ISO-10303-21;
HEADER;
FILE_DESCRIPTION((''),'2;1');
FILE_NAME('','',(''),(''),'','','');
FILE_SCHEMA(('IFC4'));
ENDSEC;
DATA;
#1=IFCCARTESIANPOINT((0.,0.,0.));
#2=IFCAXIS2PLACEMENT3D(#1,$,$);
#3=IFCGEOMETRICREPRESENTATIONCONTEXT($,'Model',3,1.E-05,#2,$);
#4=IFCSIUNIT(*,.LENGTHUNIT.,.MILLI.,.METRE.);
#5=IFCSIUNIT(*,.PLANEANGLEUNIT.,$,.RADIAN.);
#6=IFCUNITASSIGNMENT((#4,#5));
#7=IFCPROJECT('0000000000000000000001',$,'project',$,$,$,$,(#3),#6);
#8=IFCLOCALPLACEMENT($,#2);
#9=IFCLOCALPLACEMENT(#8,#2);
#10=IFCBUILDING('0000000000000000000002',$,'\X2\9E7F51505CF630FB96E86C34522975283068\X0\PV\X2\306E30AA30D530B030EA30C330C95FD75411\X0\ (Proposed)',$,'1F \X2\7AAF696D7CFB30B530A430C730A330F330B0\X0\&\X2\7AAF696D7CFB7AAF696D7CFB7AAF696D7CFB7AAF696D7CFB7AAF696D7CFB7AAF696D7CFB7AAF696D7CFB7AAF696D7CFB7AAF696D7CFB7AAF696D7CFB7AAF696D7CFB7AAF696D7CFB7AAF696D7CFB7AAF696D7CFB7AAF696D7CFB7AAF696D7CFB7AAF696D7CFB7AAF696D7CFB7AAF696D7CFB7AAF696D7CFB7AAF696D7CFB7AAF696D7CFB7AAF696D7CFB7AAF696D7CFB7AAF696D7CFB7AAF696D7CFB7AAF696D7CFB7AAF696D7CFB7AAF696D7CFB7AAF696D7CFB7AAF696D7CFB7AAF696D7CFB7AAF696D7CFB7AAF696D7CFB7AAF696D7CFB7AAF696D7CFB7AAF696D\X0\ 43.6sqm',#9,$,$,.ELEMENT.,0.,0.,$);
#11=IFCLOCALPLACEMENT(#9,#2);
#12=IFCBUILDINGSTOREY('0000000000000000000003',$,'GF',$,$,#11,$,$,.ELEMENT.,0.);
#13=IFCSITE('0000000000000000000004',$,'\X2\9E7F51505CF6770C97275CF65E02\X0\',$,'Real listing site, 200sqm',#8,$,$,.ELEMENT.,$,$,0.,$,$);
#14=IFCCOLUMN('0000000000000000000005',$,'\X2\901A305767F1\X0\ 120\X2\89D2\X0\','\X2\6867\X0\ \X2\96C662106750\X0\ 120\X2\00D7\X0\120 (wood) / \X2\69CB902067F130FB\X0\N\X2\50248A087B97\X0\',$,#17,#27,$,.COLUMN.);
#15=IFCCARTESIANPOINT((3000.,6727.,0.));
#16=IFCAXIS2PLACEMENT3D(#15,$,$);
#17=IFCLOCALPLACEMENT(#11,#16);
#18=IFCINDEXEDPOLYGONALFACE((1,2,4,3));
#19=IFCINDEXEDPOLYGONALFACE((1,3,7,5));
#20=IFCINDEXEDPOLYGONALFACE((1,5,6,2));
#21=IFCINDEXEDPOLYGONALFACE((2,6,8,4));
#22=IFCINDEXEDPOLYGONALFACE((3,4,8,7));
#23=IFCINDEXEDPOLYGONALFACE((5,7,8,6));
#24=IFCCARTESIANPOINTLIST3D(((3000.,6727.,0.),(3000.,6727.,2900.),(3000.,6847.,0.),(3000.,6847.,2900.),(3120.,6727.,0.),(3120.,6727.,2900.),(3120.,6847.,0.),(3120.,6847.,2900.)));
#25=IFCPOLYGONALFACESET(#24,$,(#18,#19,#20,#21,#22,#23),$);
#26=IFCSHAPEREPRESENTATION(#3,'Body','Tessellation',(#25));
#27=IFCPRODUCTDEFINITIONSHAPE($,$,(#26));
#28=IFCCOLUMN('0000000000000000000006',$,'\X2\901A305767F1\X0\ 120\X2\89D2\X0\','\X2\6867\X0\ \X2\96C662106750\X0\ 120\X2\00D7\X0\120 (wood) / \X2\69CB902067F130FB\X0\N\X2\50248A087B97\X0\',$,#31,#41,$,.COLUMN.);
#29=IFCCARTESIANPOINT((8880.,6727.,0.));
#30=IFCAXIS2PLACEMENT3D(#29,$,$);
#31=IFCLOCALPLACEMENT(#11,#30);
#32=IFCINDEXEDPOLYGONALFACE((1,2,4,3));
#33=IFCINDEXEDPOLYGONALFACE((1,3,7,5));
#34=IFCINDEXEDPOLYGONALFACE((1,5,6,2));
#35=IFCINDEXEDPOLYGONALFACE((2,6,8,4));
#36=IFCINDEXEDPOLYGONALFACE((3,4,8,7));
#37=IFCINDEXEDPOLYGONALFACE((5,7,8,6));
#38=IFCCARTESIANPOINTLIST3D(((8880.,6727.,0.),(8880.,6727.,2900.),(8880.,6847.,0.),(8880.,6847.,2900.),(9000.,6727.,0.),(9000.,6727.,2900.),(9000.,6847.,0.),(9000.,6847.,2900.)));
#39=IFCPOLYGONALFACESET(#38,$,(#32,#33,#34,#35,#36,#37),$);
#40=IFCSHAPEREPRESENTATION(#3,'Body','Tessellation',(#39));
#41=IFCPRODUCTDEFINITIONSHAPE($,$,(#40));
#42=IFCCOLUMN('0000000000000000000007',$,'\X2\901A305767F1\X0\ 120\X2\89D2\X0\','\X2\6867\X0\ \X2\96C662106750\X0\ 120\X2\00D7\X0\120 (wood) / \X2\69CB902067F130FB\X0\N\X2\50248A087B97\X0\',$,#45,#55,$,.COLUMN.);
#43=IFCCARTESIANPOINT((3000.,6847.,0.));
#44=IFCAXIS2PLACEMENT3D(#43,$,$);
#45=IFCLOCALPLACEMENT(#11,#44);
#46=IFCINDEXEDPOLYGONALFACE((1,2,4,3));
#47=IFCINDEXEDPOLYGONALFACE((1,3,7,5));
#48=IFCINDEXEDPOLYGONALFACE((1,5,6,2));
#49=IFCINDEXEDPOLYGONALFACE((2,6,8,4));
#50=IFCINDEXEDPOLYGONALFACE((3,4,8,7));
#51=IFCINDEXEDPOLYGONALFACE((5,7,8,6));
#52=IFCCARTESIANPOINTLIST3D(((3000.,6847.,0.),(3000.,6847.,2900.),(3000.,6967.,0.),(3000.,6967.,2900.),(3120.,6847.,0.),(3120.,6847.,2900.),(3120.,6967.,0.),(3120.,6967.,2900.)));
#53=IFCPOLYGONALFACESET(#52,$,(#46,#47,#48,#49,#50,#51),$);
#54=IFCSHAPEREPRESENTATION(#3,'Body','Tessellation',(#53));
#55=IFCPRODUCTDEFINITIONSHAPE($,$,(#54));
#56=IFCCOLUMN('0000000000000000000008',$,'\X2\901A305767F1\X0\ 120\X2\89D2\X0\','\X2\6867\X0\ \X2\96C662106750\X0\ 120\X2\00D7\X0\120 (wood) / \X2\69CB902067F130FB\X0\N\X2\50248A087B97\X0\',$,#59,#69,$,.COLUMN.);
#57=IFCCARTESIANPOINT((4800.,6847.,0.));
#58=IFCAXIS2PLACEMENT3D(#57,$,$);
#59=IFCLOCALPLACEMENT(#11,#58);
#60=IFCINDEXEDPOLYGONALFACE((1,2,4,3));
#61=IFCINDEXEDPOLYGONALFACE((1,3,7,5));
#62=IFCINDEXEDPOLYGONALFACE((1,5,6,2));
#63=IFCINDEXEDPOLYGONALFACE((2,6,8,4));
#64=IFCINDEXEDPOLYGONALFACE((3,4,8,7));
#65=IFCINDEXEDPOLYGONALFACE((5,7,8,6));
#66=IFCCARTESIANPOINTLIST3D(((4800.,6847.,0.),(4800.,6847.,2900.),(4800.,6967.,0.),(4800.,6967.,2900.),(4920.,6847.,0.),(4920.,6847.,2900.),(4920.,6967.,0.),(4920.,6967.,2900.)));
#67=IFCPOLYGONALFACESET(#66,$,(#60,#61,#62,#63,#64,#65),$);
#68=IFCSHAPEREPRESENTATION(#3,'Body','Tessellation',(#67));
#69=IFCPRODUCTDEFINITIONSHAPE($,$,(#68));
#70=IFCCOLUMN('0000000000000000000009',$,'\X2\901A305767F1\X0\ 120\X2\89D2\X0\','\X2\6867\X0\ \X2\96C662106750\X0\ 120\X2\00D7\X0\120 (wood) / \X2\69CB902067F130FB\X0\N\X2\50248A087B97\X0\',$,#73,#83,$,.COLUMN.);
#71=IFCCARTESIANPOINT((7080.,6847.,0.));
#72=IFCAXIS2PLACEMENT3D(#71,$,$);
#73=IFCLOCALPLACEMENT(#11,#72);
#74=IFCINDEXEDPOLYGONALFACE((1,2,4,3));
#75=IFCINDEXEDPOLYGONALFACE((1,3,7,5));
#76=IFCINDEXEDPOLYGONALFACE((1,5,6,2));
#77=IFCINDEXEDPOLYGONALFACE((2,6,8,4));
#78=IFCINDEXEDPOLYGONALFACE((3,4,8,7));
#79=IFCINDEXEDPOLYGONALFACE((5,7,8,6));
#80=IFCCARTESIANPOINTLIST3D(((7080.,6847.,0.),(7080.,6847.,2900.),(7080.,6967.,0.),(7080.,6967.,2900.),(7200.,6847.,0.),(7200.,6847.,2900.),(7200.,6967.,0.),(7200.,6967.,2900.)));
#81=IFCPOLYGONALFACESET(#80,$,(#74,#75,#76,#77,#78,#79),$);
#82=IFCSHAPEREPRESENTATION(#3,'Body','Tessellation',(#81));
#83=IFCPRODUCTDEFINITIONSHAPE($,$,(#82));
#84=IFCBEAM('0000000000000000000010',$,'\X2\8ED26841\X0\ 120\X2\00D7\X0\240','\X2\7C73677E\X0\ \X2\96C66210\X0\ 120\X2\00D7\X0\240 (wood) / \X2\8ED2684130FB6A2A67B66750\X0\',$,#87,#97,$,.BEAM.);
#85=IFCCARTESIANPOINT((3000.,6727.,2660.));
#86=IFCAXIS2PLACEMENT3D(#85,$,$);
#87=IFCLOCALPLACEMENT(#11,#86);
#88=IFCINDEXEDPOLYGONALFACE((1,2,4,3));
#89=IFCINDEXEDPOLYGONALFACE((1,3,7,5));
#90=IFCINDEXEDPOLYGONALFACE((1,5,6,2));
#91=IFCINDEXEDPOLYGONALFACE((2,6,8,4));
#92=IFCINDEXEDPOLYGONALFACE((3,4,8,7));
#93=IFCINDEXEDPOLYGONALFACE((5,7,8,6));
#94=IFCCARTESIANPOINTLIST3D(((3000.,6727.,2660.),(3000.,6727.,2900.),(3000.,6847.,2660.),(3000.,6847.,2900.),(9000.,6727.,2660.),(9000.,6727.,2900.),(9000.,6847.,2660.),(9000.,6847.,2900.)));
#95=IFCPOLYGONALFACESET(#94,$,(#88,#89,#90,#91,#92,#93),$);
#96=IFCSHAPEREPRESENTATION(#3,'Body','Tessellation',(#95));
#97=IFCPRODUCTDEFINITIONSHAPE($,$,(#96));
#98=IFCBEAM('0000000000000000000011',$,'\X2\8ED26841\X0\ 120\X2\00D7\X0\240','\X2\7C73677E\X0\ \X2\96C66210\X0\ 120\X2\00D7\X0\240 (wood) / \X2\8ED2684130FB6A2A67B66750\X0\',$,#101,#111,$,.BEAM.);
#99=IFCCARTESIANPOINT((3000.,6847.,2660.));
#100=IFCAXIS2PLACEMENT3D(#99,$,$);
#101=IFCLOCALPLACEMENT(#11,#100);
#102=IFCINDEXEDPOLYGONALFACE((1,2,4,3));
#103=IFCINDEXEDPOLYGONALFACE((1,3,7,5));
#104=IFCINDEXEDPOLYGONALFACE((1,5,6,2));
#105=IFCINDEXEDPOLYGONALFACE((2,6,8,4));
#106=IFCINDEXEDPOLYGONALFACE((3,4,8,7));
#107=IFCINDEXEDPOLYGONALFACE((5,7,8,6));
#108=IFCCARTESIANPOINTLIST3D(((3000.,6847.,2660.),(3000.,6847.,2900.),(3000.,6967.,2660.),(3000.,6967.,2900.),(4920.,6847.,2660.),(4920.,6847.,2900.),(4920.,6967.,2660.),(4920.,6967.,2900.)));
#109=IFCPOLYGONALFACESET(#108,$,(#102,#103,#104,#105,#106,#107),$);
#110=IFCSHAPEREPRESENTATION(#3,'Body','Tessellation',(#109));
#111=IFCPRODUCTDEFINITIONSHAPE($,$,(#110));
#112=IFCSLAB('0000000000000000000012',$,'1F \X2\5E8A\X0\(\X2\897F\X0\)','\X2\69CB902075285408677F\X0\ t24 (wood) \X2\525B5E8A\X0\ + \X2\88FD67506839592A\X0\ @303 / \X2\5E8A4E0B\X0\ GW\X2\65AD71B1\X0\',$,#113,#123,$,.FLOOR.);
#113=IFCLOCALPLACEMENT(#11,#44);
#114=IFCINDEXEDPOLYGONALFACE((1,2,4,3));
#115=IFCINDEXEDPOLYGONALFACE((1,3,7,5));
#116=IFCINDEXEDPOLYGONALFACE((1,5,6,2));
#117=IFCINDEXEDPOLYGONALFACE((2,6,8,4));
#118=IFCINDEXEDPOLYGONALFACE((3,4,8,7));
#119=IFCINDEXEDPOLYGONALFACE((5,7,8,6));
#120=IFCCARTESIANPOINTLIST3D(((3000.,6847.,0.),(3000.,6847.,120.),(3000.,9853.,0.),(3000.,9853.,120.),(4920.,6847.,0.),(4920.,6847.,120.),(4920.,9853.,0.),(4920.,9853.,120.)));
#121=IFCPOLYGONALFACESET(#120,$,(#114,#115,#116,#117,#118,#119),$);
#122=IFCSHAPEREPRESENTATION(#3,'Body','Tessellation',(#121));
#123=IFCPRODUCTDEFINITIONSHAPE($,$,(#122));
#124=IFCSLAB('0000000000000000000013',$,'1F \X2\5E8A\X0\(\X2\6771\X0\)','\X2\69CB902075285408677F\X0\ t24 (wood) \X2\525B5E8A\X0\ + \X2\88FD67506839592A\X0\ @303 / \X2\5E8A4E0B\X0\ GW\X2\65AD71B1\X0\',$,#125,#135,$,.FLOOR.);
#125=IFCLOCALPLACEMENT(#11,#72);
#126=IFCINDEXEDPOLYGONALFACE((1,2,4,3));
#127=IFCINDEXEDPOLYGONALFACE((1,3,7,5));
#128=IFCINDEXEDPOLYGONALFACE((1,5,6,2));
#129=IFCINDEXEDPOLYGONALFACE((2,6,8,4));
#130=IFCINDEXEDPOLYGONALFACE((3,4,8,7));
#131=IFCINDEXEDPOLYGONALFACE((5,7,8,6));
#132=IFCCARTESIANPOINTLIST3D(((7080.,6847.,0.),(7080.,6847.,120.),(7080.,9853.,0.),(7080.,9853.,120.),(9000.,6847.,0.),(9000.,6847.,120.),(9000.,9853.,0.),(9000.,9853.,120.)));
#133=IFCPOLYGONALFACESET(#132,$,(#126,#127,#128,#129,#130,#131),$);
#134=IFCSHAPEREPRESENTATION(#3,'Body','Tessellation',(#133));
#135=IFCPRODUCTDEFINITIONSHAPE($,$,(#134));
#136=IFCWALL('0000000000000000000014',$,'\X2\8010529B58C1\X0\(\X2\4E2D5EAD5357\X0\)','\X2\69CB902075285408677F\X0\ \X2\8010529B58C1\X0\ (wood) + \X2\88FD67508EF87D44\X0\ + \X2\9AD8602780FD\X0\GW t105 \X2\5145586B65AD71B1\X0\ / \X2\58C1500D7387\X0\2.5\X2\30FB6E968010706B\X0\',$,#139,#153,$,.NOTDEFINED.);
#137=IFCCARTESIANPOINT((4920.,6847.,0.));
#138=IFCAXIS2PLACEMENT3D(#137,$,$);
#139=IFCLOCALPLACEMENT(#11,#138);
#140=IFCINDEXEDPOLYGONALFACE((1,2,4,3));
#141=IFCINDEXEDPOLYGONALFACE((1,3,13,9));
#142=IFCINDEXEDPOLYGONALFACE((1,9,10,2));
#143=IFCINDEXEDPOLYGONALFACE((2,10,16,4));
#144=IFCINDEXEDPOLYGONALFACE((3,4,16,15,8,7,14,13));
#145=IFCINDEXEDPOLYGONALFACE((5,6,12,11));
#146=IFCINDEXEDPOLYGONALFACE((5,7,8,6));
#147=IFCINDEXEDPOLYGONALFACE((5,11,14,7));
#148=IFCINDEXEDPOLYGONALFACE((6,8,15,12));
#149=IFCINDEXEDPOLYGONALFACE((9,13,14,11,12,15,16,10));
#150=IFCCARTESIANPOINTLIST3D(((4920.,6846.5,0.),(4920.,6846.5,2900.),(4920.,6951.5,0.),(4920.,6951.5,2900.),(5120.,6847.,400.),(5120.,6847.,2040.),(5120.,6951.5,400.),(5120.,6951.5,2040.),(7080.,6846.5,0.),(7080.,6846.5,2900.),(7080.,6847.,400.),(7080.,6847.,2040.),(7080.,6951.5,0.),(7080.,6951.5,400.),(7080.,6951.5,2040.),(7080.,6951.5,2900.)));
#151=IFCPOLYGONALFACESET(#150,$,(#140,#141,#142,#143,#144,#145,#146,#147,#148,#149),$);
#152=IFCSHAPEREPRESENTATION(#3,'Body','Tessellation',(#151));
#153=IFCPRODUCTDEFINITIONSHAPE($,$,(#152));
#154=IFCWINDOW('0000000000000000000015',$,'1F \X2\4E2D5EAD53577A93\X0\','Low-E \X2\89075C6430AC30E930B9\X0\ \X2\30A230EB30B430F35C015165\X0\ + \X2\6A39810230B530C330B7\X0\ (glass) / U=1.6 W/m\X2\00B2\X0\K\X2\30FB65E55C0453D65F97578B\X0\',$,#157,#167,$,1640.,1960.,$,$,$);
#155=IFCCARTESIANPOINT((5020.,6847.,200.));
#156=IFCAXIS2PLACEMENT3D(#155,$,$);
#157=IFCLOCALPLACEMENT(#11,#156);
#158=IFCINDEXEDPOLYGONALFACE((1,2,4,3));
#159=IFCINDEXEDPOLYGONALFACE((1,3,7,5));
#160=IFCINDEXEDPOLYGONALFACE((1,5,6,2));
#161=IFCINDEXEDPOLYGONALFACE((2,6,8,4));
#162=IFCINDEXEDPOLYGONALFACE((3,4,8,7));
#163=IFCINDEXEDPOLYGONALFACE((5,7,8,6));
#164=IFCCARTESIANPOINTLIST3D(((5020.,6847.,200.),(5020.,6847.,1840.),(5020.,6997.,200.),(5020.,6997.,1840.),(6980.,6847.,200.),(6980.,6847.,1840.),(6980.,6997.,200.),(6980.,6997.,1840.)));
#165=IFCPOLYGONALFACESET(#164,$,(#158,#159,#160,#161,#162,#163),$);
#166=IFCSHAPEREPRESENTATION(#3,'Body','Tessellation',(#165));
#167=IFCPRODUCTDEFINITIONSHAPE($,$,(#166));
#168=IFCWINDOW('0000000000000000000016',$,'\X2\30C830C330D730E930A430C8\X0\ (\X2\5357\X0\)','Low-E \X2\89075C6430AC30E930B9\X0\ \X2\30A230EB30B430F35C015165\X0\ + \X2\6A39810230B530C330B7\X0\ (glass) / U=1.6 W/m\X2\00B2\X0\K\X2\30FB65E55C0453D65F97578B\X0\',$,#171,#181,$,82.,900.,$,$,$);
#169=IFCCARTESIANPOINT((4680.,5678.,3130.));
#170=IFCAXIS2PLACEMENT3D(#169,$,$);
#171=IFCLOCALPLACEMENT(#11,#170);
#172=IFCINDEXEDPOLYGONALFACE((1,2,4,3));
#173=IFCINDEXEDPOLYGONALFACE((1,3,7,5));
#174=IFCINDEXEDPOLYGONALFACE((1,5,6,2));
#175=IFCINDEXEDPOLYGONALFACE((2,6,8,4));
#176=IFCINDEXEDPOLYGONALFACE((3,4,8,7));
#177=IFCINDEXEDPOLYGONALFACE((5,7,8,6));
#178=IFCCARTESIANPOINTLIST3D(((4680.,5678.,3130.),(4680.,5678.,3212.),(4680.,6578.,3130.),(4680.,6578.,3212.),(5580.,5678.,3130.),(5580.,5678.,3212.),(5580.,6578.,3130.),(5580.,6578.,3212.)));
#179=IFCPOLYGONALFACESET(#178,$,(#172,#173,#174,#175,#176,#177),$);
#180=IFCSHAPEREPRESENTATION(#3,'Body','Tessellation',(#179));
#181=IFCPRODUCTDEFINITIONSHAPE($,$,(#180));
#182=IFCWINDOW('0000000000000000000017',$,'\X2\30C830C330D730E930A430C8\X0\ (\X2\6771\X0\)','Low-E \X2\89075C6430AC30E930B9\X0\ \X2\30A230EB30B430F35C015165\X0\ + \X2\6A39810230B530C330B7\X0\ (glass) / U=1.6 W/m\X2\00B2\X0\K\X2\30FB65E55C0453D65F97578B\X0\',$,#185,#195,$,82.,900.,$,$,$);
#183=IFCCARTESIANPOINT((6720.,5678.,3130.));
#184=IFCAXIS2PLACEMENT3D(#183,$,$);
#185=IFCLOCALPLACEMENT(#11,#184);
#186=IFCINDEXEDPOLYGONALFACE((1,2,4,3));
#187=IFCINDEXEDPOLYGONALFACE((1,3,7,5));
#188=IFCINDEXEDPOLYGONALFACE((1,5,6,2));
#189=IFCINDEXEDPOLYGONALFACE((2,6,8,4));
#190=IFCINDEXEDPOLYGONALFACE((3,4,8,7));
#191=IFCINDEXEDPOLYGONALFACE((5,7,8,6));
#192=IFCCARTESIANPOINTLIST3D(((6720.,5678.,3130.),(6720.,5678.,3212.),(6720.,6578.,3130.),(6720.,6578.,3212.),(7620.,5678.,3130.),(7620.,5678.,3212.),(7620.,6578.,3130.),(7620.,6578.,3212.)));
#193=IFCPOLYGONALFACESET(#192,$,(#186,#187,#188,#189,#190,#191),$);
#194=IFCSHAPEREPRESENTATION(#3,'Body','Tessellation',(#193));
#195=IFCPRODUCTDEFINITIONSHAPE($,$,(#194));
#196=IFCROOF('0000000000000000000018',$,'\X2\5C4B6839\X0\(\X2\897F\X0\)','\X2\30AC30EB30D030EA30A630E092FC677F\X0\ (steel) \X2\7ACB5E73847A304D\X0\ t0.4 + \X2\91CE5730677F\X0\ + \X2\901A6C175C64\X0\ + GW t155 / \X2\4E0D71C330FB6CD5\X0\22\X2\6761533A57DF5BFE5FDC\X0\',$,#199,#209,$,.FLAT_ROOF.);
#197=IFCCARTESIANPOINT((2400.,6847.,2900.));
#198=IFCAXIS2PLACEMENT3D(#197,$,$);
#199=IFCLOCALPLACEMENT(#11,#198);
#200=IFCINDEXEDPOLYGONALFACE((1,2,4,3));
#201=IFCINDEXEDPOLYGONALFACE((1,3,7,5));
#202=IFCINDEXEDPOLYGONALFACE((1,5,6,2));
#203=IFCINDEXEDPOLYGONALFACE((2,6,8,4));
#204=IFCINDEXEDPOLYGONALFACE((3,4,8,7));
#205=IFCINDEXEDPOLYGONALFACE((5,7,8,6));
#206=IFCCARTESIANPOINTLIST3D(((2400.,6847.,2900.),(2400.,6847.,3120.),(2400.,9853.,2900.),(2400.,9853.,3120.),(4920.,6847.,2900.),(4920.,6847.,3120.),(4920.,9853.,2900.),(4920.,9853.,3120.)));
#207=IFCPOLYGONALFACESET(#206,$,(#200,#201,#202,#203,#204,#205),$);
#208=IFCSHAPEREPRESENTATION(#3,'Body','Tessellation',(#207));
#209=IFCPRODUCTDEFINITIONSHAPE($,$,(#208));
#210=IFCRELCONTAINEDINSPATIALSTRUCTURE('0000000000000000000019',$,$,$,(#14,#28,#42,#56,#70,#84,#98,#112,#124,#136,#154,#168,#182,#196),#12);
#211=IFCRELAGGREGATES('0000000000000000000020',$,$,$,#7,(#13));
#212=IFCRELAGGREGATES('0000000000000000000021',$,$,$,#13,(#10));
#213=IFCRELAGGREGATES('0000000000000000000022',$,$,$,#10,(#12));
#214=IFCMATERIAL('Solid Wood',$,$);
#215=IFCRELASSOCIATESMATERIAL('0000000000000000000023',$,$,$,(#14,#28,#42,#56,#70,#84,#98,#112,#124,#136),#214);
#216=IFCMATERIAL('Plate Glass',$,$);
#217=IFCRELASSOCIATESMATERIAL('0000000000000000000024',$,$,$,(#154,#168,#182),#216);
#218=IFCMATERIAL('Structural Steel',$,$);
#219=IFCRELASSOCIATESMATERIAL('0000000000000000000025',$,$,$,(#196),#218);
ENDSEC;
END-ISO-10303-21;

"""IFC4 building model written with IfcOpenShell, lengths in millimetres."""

from ifc_helpers import new_model, si_unit, frame, frame_2d, origin, place, context, project, spatial, rectangle, extrude, material, element, fill, save


model = new_model("IFC4")

# Units and contexts
model_context = context("Model", 3, precision=1e-05, world=origin())
ifc_project = project(units=[si_unit("LENGTHUNIT", "METRE", prefix="MILLI"), si_unit("PLANEANGLEUNIT", "RADIAN")], contexts=[model_context])

# Site, building, storey
site_placement = place(None, origin())
site = spatial("IfcSite", under=ifc_project, at=site_placement, Name="鹿児島県霧島市", ObjectType="Real listing site, 200sqm", CompositionType="ELEMENT", RefElevation=0.0)
building_placement = place(site_placement, origin())
building = spatial("IfcBuilding", under=site, at=building_placement, Name="鹿児島・雨水利用とPVのオフグリッド志向 (Proposed)", ObjectType="1F 窯業系サイディング&窯業系窯業系窯業系窯業系窯業系窯業系窯業系窯業系窯業系窯業系窯業系窯業系窯業系窯業系窯業系窯業系窯業系窯業系窯業系窯業系窯業系窯業系窯業系窯業系窯業系窯業系窯業系窯業系窯業系窯業系窯業系窯業系窯業系窯業系窯業系窯業系窯業 43.6sqm", CompositionType="ELEMENT", ElevationOfRefHeight=0.0, ElevationOfTerrain=0.0)
storey_placement = place(building_placement, origin())
storey = spatial("IfcBuildingStorey", under=building, at=storey_placement, Name="GF", CompositionType="ELEMENT", Elevation=0.0)

# Columns
ifc_material_1 = material(Name="Solid Wood")
column_1_placement = place(storey_placement, frame((3000.0, 6727.0, 0.0)))
element("IfcColumn", 1, at=column_1_placement, inside=storey, material=ifc_material_1, Name="通し柱 120角", Description="桧 集成材 120×120 (wood) / 構造柱・N値計算", PredefinedType="COLUMN", context=model_context, shape_type="SweptSolid", body=[
    extrude(rectangle(XDim=120.0, YDim=120.0, at=frame_2d((60.0, 60.0))), frame((3000.0, 6727.0, 0.0)), (0.0, 0.0, 1.0), 2900.0),
])
column_2_placement = place(storey_placement, frame((8880.0, 6727.0, 0.0)))
element("IfcColumn", 2, at=column_2_placement, inside=storey, material=ifc_material_1, Name="通し柱 120角", Description="桧 集成材 120×120 (wood) / 構造柱・N値計算", PredefinedType="COLUMN", context=model_context, shape_type="SweptSolid", body=[
    extrude(rectangle(XDim=120.0, YDim=120.0, at=frame_2d((60.0, 60.0))), frame((8880.0, 6727.0, 0.0)), (0.0, 0.0, 1.0), 2900.0),
])
column_3_placement = place(storey_placement, frame((3000.0, 6847.0, 0.0)))
element("IfcColumn", 3, at=column_3_placement, inside=storey, material=ifc_material_1, Name="通し柱 120角", Description="桧 集成材 120×120 (wood) / 構造柱・N値計算", PredefinedType="COLUMN", context=model_context, shape_type="SweptSolid", body=[
    extrude(rectangle(XDim=120.0, YDim=120.0, at=frame_2d((60.0, 60.0))), frame((3000.0, 6847.0, 0.0)), (0.0, 0.0, 1.0), 2900.0),
])
column_4_placement = place(storey_placement, frame((4800.0, 6847.0, 0.0)))
element("IfcColumn", 4, at=column_4_placement, inside=storey, material=ifc_material_1, Name="通し柱 120角", Description="桧 集成材 120×120 (wood) / 構造柱・N値計算", PredefinedType="COLUMN", context=model_context, shape_type="SweptSolid", body=[
    extrude(rectangle(XDim=120.0, YDim=120.0, at=frame_2d((60.0, 60.0))), frame((4800.0, 6847.0, 0.0)), (0.0, 0.0, 1.0), 2900.0),
])
column_5_placement = place(storey_placement, frame((7080.0, 6847.0, 0.0)))
element("IfcColumn", 5, at=column_5_placement, inside=storey, material=ifc_material_1, Name="通し柱 120角", Description="桧 集成材 120×120 (wood) / 構造柱・N値計算", PredefinedType="COLUMN", context=model_context, shape_type="SweptSolid", body=[
    extrude(rectangle(XDim=120.0, YDim=120.0, at=frame_2d((60.0, 60.0))), frame((7080.0, 6847.0, 0.0)), (0.0, 0.0, 1.0), 2900.0),
])

# Beams
beam_1_placement = place(storey_placement, frame((3000.0, 6727.0, 2660.0)))
element("IfcBeam", 6, at=beam_1_placement, inside=storey, material=ifc_material_1, Name="軒桁 120×240", Description="米松 集成 120×240 (wood) / 軒桁・横架材", PredefinedType="BEAM", context=model_context, shape_type="SweptSolid", body=[
    extrude(rectangle(XDim=6000.0, YDim=120.0, at=frame_2d((3000.0, 60.0))), frame((3000.0, 6727.0, 2660.0)), (0.0, 0.0, 1.0), 240.0),
])
beam_2_placement = place(storey_placement, frame((3000.0, 6847.0, 2660.0)))
element("IfcBeam", 7, at=beam_2_placement, inside=storey, material=ifc_material_1, Name="軒桁 120×240", Description="米松 集成 120×240 (wood) / 軒桁・横架材", PredefinedType="BEAM", context=model_context, shape_type="SweptSolid", body=[
    extrude(rectangle(XDim=1920.0, YDim=120.0, at=frame_2d((960.0, 60.0))), frame((3000.0, 6847.0, 2660.0)), (0.0, 0.0, 1.0), 240.0),
])

# Slabs
slab_1_placement = place(storey_placement, frame((3000.0, 6847.0, 0.0)))
element("IfcSlab", 8, at=slab_1_placement, inside=storey, material=ifc_material_1, Name="1F 床(西)", Description="構造用合板 t24 (wood) 剛床 + 製材根太 @303 / 床下 GW断熱", PredefinedType="FLOOR", context=model_context, shape_type="SweptSolid", body=[
    extrude(rectangle(XDim=1920.0, YDim=3006.0, at=frame_2d((960.0, 1503.0))), frame((3000.0, 6847.0, 0.0)), (0.0, 0.0, 1.0), 120.0),
])
slab_2_placement = place(storey_placement, frame((7080.0, 6847.0, 0.0)))
element("IfcSlab", 9, at=slab_2_placement, inside=storey, material=ifc_material_1, Name="1F 床(東)", Description="構造用合板 t24 (wood) 剛床 + 製材根太 @303 / 床下 GW断熱", PredefinedType="FLOOR", context=model_context, shape_type="SweptSolid", body=[
    extrude(rectangle(XDim=1920.0, YDim=3006.0, at=frame_2d((960.0, 1503.0))), frame((7080.0, 6847.0, 0.0)), (0.0, 0.0, 1.0), 120.0),
])

# Wall, opening, window
wall_1_placement = place(storey_placement, frame((4920.0, 6847.0, 0.0)))
wall_1 = element("IfcWall", 10, at=wall_1_placement, inside=storey, material=ifc_material_1, Name="耐力壁(中庭南)", Description="構造用合板 耐力壁 (wood) + 製材軸組 + 高性能GW t105 充填断熱 / 壁倍率2.5・準耐火", PredefinedType="NOTDEFINED", context=model_context, shape_type="SweptSolid", body=[
    extrude(rectangle(XDim=2160.0, YDim=105.0, at=frame_2d((1080.0, 52.0))), frame((4920.0, 6847.0, 0.0)), (0.0, 0.0, 1.0), 2900.0),
])
opening_placement = place(storey_placement, frame((5020.0, 6847.0, 200.0)))
opening = element("IfcOpeningElement", 11, at=opening_placement, cuts=wall_1, PredefinedType="NOTDEFINED", context=model_context, shape_type="SweptSolid", body=[
    extrude(rectangle(XDim=1960.0, YDim=150.0, at=frame_2d((980.0, 75.0))), frame((5020.0, 6847.0, 200.0)), (0.0, 0.0, 1.0), 1640.0),
])
ifc_material_2 = material(Name="Plate Glass")
window_1_placement = place(storey_placement, frame((5020.0, 6847.0, 200.0)))
window_1 = element("IfcWindow", 12, at=window_1_placement, inside=storey, material=ifc_material_2, Name="1F 中庭南窓", Description="Low-E 複層ガラス アルゴン封入 + 樹脂サッシ (glass) / U=1.6 W/m²K・日射取得型", OverallHeight=1640.0, OverallWidth=1960.0, context=model_context, shape_type="SweptSolid", body=[
    extrude(rectangle(XDim=1960.0, YDim=150.0, at=frame_2d((980.0, 75.0))), frame((5020.0, 6847.0, 200.0)), (0.0, 0.0, 1.0), 1640.0),
])
fill(opening, window_1)

# Windows
window_2_placement = place(storey_placement, frame((4680.0, 5678.0, 3130.0)))
element("IfcWindow", 13, at=window_2_placement, inside=storey, material=ifc_material_2, Name="トップライト (南)", Description="Low-E 複層ガラス アルゴン封入 + 樹脂サッシ (glass) / U=1.6 W/m²K・日射取得型", OverallHeight=82.0, OverallWidth=900.0, context=model_context, shape_type="SweptSolid", body=[
    extrude(rectangle(XDim=900.0, YDim=900.0, at=frame_2d((450.0, 450.0))), frame((4680.0, 5678.0, 3130.0)), (0.0, 0.0, 1.0), 82.0),
])
window_3_placement = place(storey_placement, frame((6720.0, 5678.0, 3130.0)))
element("IfcWindow", 14, at=window_3_placement, inside=storey, material=ifc_material_2, Name="トップライト (東)", Description="Low-E 複層ガラス アルゴン封入 + 樹脂サッシ (glass) / U=1.6 W/m²K・日射取得型", OverallHeight=82.0, OverallWidth=900.0, context=model_context, shape_type="SweptSolid", body=[
    extrude(rectangle(XDim=900.0, YDim=900.0, at=frame_2d((450.0, 450.0))), frame((6720.0, 5678.0, 3130.0)), (0.0, 0.0, 1.0), 82.0),
])

# Roof
ifc_material_3 = material(Name="Structural Steel")
roof_1_placement = place(storey_placement, frame((2400.0, 6847.0, 2900.0)))
element("IfcRoof", 15, at=roof_1_placement, inside=storey, material=ifc_material_3, Name="屋根(西)", Description="ガルバリウム鋼板 (steel) 立平葺き t0.4 + 野地板 + 通気層 + GW t155 / 不燃・法22条区域対応", PredefinedType="FLAT_ROOF", context=model_context, shape_type="SweptSolid", body=[
    extrude(rectangle(XDim=2520.0, YDim=3006.0, at=frame_2d((1260.0, 1503.0))), frame((2400.0, 6847.0, 2900.0)), (0.0, 0.0, 1.0), 220.0),
])

save(model, "model.ifc")
